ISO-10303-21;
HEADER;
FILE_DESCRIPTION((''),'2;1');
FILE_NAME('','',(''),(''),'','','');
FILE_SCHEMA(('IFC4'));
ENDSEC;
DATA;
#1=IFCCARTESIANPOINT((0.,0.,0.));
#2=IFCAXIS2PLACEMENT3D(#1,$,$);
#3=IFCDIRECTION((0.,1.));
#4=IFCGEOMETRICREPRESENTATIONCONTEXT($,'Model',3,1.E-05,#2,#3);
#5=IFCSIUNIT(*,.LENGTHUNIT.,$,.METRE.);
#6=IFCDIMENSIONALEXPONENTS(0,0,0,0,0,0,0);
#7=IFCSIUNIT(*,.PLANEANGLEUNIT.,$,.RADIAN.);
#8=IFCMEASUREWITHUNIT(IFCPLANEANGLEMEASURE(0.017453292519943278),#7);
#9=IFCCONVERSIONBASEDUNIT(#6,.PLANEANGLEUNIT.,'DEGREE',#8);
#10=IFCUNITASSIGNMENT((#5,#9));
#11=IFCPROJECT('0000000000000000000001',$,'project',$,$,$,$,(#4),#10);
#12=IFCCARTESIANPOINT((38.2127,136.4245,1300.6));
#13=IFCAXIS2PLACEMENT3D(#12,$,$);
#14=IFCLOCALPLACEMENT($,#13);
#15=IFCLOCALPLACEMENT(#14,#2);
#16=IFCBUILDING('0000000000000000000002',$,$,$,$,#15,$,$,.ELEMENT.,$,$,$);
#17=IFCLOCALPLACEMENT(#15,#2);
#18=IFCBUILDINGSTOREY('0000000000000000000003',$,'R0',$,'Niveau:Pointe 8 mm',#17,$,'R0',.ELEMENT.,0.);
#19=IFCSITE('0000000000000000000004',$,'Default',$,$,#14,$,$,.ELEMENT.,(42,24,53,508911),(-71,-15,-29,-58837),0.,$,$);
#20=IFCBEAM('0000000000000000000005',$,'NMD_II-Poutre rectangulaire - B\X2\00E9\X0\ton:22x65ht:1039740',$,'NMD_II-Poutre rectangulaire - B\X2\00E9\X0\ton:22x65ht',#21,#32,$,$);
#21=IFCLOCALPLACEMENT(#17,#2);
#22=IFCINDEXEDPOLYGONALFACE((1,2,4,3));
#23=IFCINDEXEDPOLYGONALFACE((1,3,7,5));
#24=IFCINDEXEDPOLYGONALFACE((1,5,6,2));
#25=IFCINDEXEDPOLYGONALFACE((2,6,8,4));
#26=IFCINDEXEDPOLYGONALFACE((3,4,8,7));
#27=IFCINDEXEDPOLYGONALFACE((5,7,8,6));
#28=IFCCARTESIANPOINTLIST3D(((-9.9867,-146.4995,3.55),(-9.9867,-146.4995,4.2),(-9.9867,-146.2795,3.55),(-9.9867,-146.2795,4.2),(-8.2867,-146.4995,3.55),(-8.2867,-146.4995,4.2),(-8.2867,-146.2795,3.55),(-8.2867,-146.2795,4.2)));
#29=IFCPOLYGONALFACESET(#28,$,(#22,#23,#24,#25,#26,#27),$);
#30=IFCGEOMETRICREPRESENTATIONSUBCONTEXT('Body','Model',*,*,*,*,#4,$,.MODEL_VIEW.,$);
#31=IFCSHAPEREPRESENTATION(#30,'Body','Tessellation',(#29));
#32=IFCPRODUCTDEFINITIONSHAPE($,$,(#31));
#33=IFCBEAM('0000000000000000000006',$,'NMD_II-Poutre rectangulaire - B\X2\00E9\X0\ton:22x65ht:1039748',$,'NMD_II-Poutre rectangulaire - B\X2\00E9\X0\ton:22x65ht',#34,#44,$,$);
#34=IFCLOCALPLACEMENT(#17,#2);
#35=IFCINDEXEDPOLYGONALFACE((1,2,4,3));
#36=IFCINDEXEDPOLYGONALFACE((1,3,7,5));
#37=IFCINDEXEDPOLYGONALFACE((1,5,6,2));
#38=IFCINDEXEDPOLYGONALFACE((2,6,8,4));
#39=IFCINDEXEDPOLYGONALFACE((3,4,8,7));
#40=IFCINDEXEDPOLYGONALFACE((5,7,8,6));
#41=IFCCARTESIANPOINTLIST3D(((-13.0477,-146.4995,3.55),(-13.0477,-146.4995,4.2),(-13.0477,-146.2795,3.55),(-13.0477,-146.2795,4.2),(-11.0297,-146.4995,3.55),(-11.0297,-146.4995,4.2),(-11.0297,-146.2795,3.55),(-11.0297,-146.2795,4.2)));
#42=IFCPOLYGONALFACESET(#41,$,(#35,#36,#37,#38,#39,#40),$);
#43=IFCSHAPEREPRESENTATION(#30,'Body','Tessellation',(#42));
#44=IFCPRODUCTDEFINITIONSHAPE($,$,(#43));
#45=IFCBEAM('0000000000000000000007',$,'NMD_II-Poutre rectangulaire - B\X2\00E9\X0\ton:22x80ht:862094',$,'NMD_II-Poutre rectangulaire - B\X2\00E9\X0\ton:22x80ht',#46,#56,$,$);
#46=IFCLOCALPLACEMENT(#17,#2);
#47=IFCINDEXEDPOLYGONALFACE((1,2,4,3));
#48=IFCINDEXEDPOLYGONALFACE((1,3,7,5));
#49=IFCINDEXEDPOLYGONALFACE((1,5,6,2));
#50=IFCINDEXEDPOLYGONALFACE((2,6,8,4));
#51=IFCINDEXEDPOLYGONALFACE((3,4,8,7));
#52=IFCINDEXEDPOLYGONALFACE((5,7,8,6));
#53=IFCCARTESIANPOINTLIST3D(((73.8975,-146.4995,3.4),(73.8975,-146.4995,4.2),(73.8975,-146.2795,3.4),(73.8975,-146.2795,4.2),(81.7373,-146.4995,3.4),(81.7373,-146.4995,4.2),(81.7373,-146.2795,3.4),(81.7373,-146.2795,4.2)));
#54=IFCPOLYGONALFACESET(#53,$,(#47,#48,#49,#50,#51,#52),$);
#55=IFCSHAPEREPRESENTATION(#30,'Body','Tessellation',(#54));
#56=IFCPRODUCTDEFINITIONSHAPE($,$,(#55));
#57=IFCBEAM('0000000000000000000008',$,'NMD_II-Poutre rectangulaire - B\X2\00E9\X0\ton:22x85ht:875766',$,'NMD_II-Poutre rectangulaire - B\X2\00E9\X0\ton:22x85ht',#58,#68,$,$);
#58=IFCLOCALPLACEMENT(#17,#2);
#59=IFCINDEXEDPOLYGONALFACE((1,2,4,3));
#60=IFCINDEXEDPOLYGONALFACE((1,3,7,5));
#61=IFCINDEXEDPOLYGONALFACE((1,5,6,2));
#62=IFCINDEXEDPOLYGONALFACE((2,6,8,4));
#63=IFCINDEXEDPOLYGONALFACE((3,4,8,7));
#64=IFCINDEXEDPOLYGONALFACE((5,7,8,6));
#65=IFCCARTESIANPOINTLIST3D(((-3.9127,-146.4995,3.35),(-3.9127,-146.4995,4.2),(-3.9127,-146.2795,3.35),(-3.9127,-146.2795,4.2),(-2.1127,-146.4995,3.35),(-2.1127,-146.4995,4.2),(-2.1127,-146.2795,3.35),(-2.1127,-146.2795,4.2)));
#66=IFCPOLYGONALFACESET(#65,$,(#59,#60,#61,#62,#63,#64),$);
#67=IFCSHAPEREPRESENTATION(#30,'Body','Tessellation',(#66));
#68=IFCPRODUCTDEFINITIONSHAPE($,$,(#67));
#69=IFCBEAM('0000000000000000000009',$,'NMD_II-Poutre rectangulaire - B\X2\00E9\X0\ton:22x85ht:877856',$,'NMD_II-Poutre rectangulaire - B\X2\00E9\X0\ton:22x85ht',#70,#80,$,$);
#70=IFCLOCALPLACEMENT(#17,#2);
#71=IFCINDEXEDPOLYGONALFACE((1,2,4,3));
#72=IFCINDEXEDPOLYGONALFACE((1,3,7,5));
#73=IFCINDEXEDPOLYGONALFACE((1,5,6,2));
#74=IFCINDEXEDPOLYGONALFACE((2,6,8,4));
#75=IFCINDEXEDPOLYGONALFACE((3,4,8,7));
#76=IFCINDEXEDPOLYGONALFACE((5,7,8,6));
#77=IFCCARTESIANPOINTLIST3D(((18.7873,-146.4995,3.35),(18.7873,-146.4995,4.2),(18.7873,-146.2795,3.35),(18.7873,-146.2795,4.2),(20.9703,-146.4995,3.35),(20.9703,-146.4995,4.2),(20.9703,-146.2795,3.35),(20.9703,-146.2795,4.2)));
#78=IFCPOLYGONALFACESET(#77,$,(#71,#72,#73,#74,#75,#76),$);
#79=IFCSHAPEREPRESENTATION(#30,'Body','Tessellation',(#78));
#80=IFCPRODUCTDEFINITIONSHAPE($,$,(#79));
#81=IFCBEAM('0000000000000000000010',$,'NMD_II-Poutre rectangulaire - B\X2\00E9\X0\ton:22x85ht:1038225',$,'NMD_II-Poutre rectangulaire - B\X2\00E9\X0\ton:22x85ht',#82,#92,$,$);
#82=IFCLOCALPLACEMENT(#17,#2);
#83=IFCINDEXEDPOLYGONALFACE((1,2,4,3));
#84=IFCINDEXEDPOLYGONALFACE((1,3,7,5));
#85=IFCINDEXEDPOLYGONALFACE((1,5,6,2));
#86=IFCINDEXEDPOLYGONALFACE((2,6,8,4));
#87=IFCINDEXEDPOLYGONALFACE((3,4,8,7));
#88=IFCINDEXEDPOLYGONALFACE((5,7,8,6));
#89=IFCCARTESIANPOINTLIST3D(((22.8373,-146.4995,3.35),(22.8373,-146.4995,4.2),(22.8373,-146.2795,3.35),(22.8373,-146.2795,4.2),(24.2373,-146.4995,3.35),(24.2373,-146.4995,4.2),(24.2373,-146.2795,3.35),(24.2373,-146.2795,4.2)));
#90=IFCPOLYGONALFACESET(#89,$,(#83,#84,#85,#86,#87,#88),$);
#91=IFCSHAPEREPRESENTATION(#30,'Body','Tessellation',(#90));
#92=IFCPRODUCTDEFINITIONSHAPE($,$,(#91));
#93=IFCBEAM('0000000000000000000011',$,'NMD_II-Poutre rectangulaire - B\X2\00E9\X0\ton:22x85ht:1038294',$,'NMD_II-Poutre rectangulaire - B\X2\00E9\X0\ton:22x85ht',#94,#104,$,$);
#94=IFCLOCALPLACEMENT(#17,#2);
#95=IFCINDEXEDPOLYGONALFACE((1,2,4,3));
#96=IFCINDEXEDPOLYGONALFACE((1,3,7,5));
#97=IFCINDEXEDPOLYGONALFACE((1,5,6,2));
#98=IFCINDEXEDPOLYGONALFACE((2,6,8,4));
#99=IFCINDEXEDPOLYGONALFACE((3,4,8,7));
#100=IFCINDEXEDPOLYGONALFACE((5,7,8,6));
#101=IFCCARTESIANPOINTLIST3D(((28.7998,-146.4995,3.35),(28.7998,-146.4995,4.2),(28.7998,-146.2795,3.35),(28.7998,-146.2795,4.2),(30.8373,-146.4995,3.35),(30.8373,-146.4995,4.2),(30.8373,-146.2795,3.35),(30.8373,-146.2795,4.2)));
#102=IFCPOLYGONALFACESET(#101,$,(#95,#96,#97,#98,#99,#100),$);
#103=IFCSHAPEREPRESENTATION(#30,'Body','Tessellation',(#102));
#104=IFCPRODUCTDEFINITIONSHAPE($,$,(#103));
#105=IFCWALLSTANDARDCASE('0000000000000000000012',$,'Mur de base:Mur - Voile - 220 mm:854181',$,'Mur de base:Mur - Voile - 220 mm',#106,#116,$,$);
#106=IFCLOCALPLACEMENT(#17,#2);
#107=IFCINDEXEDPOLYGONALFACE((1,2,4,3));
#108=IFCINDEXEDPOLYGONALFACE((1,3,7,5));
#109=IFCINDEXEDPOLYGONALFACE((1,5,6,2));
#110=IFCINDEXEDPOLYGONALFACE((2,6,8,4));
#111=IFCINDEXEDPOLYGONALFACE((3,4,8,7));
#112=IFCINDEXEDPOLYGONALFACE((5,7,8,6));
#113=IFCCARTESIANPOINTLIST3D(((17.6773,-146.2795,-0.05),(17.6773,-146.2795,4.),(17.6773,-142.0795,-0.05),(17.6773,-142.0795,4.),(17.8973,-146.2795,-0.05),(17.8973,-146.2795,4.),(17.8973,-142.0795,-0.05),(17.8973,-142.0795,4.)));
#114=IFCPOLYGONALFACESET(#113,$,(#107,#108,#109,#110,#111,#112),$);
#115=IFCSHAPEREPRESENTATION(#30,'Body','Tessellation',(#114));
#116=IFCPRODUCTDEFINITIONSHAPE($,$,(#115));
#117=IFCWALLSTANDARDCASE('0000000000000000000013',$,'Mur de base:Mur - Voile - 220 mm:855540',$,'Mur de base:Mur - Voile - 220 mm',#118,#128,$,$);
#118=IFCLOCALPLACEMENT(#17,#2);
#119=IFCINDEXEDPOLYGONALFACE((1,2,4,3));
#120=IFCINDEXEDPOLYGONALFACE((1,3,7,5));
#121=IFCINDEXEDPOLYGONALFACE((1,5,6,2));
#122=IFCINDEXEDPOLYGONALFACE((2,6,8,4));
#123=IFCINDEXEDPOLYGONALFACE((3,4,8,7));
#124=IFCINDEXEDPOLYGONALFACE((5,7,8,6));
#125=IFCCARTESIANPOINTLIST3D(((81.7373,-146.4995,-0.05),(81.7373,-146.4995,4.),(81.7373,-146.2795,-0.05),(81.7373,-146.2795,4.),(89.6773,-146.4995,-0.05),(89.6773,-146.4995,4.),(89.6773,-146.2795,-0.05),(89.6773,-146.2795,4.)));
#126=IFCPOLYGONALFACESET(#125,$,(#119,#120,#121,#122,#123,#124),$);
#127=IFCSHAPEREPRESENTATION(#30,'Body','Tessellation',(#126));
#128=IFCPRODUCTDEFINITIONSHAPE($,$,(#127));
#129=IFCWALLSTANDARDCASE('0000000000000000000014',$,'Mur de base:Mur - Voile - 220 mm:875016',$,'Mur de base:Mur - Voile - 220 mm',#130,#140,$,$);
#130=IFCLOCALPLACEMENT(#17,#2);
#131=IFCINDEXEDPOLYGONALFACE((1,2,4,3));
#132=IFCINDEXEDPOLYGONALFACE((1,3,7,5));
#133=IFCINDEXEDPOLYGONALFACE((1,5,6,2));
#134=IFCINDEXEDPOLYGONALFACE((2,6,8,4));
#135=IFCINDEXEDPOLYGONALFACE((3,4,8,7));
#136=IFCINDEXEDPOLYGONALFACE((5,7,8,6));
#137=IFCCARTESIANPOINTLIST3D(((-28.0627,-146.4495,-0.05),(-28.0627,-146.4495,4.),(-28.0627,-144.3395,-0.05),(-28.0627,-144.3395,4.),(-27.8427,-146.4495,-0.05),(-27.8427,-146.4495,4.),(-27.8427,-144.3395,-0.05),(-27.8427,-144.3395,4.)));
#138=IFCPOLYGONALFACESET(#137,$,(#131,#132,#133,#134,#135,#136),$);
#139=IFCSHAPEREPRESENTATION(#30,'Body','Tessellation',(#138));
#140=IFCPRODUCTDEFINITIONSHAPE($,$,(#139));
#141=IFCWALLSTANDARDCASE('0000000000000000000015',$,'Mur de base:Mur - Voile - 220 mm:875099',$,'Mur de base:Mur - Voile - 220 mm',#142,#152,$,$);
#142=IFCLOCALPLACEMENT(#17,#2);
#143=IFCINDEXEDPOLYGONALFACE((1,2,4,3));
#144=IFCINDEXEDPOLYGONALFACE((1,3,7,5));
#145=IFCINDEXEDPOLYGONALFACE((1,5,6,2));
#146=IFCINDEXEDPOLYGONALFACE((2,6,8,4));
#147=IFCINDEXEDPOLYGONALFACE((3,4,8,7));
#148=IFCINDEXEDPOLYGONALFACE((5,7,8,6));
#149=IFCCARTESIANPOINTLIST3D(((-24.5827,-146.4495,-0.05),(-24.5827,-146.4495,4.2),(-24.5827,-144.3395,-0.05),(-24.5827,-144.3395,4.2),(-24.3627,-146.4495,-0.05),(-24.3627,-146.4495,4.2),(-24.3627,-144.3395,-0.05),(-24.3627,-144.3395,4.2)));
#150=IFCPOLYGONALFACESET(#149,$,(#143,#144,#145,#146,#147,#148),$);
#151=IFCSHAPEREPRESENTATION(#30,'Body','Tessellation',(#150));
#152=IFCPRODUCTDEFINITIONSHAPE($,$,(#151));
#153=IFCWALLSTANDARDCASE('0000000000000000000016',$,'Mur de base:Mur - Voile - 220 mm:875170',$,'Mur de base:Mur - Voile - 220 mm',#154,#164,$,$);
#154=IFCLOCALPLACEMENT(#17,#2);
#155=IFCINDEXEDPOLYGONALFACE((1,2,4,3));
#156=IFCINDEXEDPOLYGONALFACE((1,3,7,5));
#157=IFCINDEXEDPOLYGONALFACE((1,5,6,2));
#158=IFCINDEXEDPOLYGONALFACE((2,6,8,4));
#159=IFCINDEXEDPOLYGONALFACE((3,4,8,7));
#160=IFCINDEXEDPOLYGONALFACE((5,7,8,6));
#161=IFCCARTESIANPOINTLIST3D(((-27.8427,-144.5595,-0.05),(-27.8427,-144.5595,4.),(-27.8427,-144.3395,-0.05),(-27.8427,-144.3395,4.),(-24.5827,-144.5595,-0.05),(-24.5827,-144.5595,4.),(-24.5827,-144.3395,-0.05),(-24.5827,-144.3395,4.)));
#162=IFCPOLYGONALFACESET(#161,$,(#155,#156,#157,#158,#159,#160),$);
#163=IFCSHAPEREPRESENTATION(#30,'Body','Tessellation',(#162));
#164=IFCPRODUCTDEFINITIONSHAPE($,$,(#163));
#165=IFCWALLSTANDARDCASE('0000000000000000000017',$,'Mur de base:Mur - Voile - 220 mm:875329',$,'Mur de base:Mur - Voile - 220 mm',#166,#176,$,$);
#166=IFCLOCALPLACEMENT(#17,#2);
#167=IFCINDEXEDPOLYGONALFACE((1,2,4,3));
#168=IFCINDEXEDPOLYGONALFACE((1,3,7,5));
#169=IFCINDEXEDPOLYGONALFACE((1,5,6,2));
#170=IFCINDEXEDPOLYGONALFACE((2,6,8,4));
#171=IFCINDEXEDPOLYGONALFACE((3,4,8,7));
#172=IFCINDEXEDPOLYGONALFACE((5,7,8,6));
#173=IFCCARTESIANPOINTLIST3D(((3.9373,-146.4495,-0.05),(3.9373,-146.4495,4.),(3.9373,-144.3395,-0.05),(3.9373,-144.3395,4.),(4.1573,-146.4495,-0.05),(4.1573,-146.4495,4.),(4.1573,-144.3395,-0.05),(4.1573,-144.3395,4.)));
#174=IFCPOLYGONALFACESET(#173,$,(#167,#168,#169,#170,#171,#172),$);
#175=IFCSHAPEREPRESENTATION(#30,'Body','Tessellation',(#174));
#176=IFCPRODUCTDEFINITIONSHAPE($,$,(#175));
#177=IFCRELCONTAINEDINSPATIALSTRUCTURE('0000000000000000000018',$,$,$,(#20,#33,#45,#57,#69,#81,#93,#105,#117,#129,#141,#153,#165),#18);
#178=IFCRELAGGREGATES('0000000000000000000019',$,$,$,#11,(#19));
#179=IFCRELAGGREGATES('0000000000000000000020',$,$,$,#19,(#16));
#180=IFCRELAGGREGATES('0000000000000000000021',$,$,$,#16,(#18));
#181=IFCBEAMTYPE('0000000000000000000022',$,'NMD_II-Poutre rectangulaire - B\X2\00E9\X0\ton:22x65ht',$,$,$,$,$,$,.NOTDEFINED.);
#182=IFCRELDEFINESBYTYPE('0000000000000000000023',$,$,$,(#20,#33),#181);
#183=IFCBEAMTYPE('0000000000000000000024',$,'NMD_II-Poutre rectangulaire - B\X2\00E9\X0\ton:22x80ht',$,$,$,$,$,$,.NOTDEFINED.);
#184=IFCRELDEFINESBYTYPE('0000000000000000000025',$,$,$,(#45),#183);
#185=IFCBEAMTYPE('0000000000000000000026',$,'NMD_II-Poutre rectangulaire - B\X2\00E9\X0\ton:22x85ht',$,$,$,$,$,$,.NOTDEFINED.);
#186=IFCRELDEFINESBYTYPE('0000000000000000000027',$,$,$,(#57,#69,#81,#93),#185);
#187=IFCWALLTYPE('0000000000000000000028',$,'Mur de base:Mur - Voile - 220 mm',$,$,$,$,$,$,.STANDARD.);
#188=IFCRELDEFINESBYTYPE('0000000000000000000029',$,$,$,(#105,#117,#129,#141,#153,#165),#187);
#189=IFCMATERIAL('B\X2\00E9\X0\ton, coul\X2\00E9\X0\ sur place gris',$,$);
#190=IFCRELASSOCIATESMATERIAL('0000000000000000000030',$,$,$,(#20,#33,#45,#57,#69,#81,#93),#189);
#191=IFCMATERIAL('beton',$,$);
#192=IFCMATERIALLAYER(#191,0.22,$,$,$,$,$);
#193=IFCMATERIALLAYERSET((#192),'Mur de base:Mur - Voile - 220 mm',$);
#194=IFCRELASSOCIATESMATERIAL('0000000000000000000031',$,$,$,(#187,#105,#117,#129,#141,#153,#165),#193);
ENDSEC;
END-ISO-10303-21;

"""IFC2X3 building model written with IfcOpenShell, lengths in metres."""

from ifc_helpers import new_model, entity, si_unit, converted_unit, direction, frame, frame_2d, origin, origin_2d_with_axis, place, context, subcontext, project, spatial, polyline, rectangle, extrude, clip, bounded_halfspace, material, layer, layer_set, layer_usage, type_object, element, save


model = new_model("IFC2X3")

# Units and contexts
model_context = context("Model", 3, precision=1e-05, world=origin(), true_north=direction((0.0, 1.0)))
body_context = subcontext(model_context, "Body", "Model", "MODEL_VIEW")
ifc_project = project(units=[si_unit("LENGTHUNIT", "METRE"), converted_unit("PLANEANGLEUNIT", "DEGREE", entity("IfcPlaneAngleMeasure", 0.017453292519943278), si_unit("PLANEANGLEUNIT", "RADIAN"), dimensions=[0, 0, 0, 0, 0, 0, 0])], contexts=[model_context])

# Site, building, storey
site_placement = place(None, frame((38.2127, 136.4245, 1300.6)))
site = spatial("IfcSite", under=ifc_project, at=site_placement, Name="Default", CompositionType="ELEMENT", RefLatitude=(42, 24, 53, 508911), RefLongitude=(-71, -15, -29, -58837), RefElevation=0.0)
building_placement = place(site_placement, origin())
building = spatial("IfcBuilding", under=site, at=building_placement, CompositionType="ELEMENT")
storey_placement = place(building_placement, origin())
storey = spatial("IfcBuildingStorey", under=building, at=storey_placement, Name="R0", ObjectType="Niveau:Pointe 8 mm", LongName="R0", CompositionType="ELEMENT", Elevation=0.0)

# Beams
ifc_material_1 = material(Name="Béton, coulé sur place gris")
beam_type_1 = type_object("IfcBeamType", Name="NMD_II-Poutre rectangulaire - Béton:22x65ht", PredefinedType="NOTDEFINED")
beam_1_placement = place(storey_placement, frame((-9.9867, -146.3895, 4.2)))
element("IfcBeam", 1, at=beam_1_placement, inside=storey, type_object=beam_type_1, material=ifc_material_1, Name="NMD_II-Poutre rectangulaire - Béton:22x65ht:1039740", ObjectType="NMD_II-Poutre rectangulaire - Béton:22x65ht", context=body_context, shape_type="SweptSolid", body=[
    extrude(rectangle(XDim=0.65, YDim=0.22, at=frame_2d((0.0, 0.0), x_axis=(1.0, 0.0))), frame((0.0, 0.0, -0.325), z_axis=(1.0, 0.0, 0.0), x_axis=(0.0, 0.0, -1.0)), (0.0, 0.0, 1.0), 1.7),
])
beam_2_placement = place(storey_placement, frame((-13.0477, -146.3895, 4.2)))
element("IfcBeam", 2, at=beam_2_placement, inside=storey, type_object=beam_type_1, material=ifc_material_1, Name="NMD_II-Poutre rectangulaire - Béton:22x65ht:1039748", ObjectType="NMD_II-Poutre rectangulaire - Béton:22x65ht", context=body_context, shape_type="SweptSolid", body=[
    extrude(rectangle(XDim=0.65, YDim=0.22, at=frame_2d((0.0, 0.0), x_axis=(1.0, 0.0))), frame((0.0, 0.0, -0.325), z_axis=(1.0, 0.0, 0.0), x_axis=(0.0, 0.0, -1.0)), (0.0, 0.0, 1.0), 2.018),
])
beam_type_2 = type_object("IfcBeamType", Name="NMD_II-Poutre rectangulaire - Béton:22x80ht", PredefinedType="NOTDEFINED")
beam_3_placement = place(storey_placement, frame((73.7875, -146.3895, 4.2)))
element("IfcBeam", 3, at=beam_3_placement, inside=storey, type_object=beam_type_2, material=ifc_material_1, Name="NMD_II-Poutre rectangulaire - Béton:22x80ht:862094", ObjectType="NMD_II-Poutre rectangulaire - Béton:22x80ht", context=body_context, shape_type="SweptSolid", body=[
    extrude(rectangle(XDim=0.8, YDim=0.22, at=frame_2d((0.0, 0.0), x_axis=(1.0, 0.0))), frame((0.11, 0.0, -0.4), z_axis=(1.0, 0.0, 0.0), x_axis=(0.0, 0.0, -1.0)), (0.0, 0.0, 1.0), 7.8398),
])
beam_type_3 = type_object("IfcBeamType", Name="NMD_II-Poutre rectangulaire - Béton:22x85ht", PredefinedType="NOTDEFINED")
beam_4_placement = place(storey_placement, frame((-3.9127, -146.3895, 4.2)))
element("IfcBeam", 4, at=beam_4_placement, inside=storey, type_object=beam_type_3, material=ifc_material_1, Name="NMD_II-Poutre rectangulaire - Béton:22x85ht:875766", ObjectType="NMD_II-Poutre rectangulaire - Béton:22x85ht", context=body_context, shape_type="SweptSolid", body=[
    extrude(rectangle(XDim=0.85, YDim=0.22, at=frame_2d((0.0, 0.0), x_axis=(1.0, 0.0))), frame((0.0, 0.0, -0.425), z_axis=(1.0, 0.0, 0.0), x_axis=(0.0, 0.0, -1.0)), (0.0, 0.0, 1.0), 1.8),
])
beam_5_placement = place(storey_placement, frame((18.7873, -146.3895, 4.2)))
element("IfcBeam", 5, at=beam_5_placement, inside=storey, type_object=beam_type_3, material=ifc_material_1, Name="NMD_II-Poutre rectangulaire - Béton:22x85ht:877856", ObjectType="NMD_II-Poutre rectangulaire - Béton:22x85ht", context=body_context, shape_type="SweptSolid", body=[
    extrude(rectangle(XDim=0.85, YDim=0.22, at=frame_2d((0.0, 0.0), x_axis=(1.0, 0.0))), frame((0.0, 0.0, -0.425), z_axis=(1.0, 0.0, 0.0), x_axis=(0.0, 0.0, -1.0)), (0.0, 0.0, 1.0), 2.183),
])
beam_6_placement = place(storey_placement, frame((22.8373, -146.3895, 4.2)))
element("IfcBeam", 6, at=beam_6_placement, inside=storey, type_object=beam_type_3, material=ifc_material_1, Name="NMD_II-Poutre rectangulaire - Béton:22x85ht:1038225", ObjectType="NMD_II-Poutre rectangulaire - Béton:22x85ht", context=body_context, shape_type="SweptSolid", body=[
    extrude(rectangle(XDim=0.85, YDim=0.22, at=origin_2d_with_axis()), frame((0.0, 0.0, -0.425), z_axis=(1.0, 0.0, 0.0), x_axis=(0.0, 0.0, -1.0)), (0.0, 0.0, 1.0), 1.4),
])
beam_7_placement = place(storey_placement, frame((28.7873, -146.3895, 4.2)))
element("IfcBeam", 7, at=beam_7_placement, inside=storey, type_object=beam_type_3, material=ifc_material_1, Name="NMD_II-Poutre rectangulaire - Béton:22x85ht:1038294", ObjectType="NMD_II-Poutre rectangulaire - Béton:22x85ht", context=body_context, shape_type="SweptSolid", body=[
    extrude(rectangle(XDim=0.85, YDim=0.22, at=frame_2d((0.0, 0.0), x_axis=(1.0, 0.0))), frame((0.0125, 0.0, -0.425), z_axis=(1.0, 0.0, 0.0), x_axis=(0.0, 0.0, -1.0)), (0.0, 0.0, 1.0), 2.0375),
])

# Walls
ifc_material_2 = material(Name="beton")
ifc_layer = layer(ifc_material_2, 0.22)
ifc_layer_set = layer_set([ifc_layer], Name="Mur de base:Mur - Voile - 220 mm")
ifc_layer_usage_1 = layer_usage(ifc_layer_set, "AXIS2", "NEGATIVE", 0.11)
wall_type = type_object("IfcWallType", Name="Mur de base:Mur - Voile - 220 mm", PredefinedType="STANDARD", material=ifc_layer_set)
wall_1_placement = place(storey_placement, frame((17.7873, -146.2795, -0.05), z_axis=(0.0, 0.0, 1.0), x_axis=(0.0, 1.0, 0.0)))
element("IfcWallStandardCase", 8, at=wall_1_placement, inside=storey, type_object=wall_type, material=ifc_layer_usage_1, Name="Mur de base:Mur - Voile - 220 mm:854181", ObjectType="Mur de base:Mur - Voile - 220 mm", context=body_context, shape_type="Clipping", body=[
    clip(extrude(rectangle(XDim=4.2, YDim=0.22, at=frame_2d((2.1, 0.0), x_axis=(-1.0, 0.0))), origin(), (0.0, 0.0, 1.0), 4.05), bounded_halfspace(frame((0.0, -0.11, 4.05), z_axis=(0.0, 0.0, -1.0), x_axis=(1.0, 0.0, 0.0)), True, frame((0.0, -0.11, 4.05)), polyline([(0.0, 0.0), (3.98, 0.0), (3.98, 0.22), (3.85, 0.22), (0.0, 0.22), (0.0, 0.0)]))),
])
ifc_layer_usage_2 = layer_usage(ifc_layer_set, "AXIS2", "NEGATIVE", 0.11)
wall_2_placement = place(storey_placement, frame((81.7373, -146.3895, -0.05)))
element("IfcWallStandardCase", 9, at=wall_2_placement, inside=storey, type_object=wall_type, material=ifc_layer_usage_2, Name="Mur de base:Mur - Voile - 220 mm:855540", ObjectType="Mur de base:Mur - Voile - 220 mm", context=body_context, shape_type="Clipping", body=[
    clip(extrude(rectangle(XDim=7.94, YDim=0.22, at=frame_2d((3.97, 0.0), x_axis=(-1.0, 0.0))), origin(), (0.0, 0.0, 1.0), 4.05), bounded_halfspace(frame((0.0, -0.11, 4.05), z_axis=(0.0, 0.0, -1.0), x_axis=(0.0, 1.0, 0.0)), True, frame((0.0, -0.11, 4.05)), polyline([(0.0, 0.0), (5.33, 0.0), (5.55, 0.0), (7.94, 0.0), (7.94, 0.22), (0.0, 0.22), (0.0, 0.0)]))),
])
ifc_layer_usage_3 = layer_usage(ifc_layer_set, "AXIS2", "POSITIVE", -0.11)
wall_3_placement = place(storey_placement, frame((-27.9527, -144.3395, -0.05), z_axis=(0.0, 0.0, 1.0), x_axis=(0.0, -1.0, 0.0)))
element("IfcWallStandardCase", 10, at=wall_3_placement, inside=storey, type_object=wall_type, material=ifc_layer_usage_3, Name="Mur de base:Mur - Voile - 220 mm:875016", ObjectType="Mur de base:Mur - Voile - 220 mm", context=body_context, shape_type="SweptSolid", body=[
    extrude(rectangle(XDim=2.11, YDim=0.22, at=frame_2d((1.055, 0.0), x_axis=(-1.0, 0.0))), origin(), (0.0, 0.0, 1.0), 4.05),
])
ifc_layer_usage_4 = layer_usage(ifc_layer_set, "AXIS2", "NEGATIVE", 0.11)
wall_4_placement = place(storey_placement, frame((-24.4727, -146.4495, -0.05), z_axis=(0.0, 0.0, 1.0), x_axis=(0.0, 1.0, 0.0)))
element("IfcWallStandardCase", 11, at=wall_4_placement, inside=storey, type_object=wall_type, material=ifc_layer_usage_4, Name="Mur de base:Mur - Voile - 220 mm:875099", ObjectType="Mur de base:Mur - Voile - 220 mm", context=body_context, shape_type="SweptSolid", body=[
    extrude(rectangle(XDim=2.11, YDim=0.22, at=frame_2d((1.055, 0.0), x_axis=(-1.0, 0.0))), origin(), (0.0, 0.0, 1.0), 4.25),
])
ifc_layer_usage_5 = layer_usage(ifc_layer_set, "AXIS2", "NEGATIVE", 0.11)
wall_5_placement = place(storey_placement, frame((-24.5827, -144.4495, -0.05), z_axis=(0.0, 0.0, 1.0), x_axis=(-1.0, 0.0, 0.0)))
element("IfcWallStandardCase", 12, at=wall_5_placement, inside=storey, type_object=wall_type, material=ifc_layer_usage_5, Name="Mur de base:Mur - Voile - 220 mm:875170", ObjectType="Mur de base:Mur - Voile - 220 mm", context=body_context, shape_type="SweptSolid", body=[
    extrude(rectangle(XDim=3.26, YDim=0.22, at=frame_2d((1.63, 0.0), x_axis=(-1.0, 0.0))), origin(), (0.0, 0.0, 1.0), 4.05),
])
ifc_layer_usage_6 = layer_usage(ifc_layer_set, "AXIS2", "POSITIVE", -0.11)
wall_6_placement = place(storey_placement, frame((4.0473, -144.3395, -0.05), z_axis=(0.0, 0.0, 1.0), x_axis=(0.0, -1.0, 0.0)))
element("IfcWallStandardCase", 13, at=wall_6_placement, inside=storey, type_object=wall_type, material=ifc_layer_usage_6, Name="Mur de base:Mur - Voile - 220 mm:875329", ObjectType="Mur de base:Mur - Voile - 220 mm", context=body_context, shape_type="SweptSolid", body=[
    extrude(rectangle(XDim=2.11, YDim=0.22, at=frame_2d((1.055, 0.0), x_axis=(-1.0, 0.0))), origin(), (0.0, 0.0, 1.0), 4.05),
])

save(model, "model.ifc")
